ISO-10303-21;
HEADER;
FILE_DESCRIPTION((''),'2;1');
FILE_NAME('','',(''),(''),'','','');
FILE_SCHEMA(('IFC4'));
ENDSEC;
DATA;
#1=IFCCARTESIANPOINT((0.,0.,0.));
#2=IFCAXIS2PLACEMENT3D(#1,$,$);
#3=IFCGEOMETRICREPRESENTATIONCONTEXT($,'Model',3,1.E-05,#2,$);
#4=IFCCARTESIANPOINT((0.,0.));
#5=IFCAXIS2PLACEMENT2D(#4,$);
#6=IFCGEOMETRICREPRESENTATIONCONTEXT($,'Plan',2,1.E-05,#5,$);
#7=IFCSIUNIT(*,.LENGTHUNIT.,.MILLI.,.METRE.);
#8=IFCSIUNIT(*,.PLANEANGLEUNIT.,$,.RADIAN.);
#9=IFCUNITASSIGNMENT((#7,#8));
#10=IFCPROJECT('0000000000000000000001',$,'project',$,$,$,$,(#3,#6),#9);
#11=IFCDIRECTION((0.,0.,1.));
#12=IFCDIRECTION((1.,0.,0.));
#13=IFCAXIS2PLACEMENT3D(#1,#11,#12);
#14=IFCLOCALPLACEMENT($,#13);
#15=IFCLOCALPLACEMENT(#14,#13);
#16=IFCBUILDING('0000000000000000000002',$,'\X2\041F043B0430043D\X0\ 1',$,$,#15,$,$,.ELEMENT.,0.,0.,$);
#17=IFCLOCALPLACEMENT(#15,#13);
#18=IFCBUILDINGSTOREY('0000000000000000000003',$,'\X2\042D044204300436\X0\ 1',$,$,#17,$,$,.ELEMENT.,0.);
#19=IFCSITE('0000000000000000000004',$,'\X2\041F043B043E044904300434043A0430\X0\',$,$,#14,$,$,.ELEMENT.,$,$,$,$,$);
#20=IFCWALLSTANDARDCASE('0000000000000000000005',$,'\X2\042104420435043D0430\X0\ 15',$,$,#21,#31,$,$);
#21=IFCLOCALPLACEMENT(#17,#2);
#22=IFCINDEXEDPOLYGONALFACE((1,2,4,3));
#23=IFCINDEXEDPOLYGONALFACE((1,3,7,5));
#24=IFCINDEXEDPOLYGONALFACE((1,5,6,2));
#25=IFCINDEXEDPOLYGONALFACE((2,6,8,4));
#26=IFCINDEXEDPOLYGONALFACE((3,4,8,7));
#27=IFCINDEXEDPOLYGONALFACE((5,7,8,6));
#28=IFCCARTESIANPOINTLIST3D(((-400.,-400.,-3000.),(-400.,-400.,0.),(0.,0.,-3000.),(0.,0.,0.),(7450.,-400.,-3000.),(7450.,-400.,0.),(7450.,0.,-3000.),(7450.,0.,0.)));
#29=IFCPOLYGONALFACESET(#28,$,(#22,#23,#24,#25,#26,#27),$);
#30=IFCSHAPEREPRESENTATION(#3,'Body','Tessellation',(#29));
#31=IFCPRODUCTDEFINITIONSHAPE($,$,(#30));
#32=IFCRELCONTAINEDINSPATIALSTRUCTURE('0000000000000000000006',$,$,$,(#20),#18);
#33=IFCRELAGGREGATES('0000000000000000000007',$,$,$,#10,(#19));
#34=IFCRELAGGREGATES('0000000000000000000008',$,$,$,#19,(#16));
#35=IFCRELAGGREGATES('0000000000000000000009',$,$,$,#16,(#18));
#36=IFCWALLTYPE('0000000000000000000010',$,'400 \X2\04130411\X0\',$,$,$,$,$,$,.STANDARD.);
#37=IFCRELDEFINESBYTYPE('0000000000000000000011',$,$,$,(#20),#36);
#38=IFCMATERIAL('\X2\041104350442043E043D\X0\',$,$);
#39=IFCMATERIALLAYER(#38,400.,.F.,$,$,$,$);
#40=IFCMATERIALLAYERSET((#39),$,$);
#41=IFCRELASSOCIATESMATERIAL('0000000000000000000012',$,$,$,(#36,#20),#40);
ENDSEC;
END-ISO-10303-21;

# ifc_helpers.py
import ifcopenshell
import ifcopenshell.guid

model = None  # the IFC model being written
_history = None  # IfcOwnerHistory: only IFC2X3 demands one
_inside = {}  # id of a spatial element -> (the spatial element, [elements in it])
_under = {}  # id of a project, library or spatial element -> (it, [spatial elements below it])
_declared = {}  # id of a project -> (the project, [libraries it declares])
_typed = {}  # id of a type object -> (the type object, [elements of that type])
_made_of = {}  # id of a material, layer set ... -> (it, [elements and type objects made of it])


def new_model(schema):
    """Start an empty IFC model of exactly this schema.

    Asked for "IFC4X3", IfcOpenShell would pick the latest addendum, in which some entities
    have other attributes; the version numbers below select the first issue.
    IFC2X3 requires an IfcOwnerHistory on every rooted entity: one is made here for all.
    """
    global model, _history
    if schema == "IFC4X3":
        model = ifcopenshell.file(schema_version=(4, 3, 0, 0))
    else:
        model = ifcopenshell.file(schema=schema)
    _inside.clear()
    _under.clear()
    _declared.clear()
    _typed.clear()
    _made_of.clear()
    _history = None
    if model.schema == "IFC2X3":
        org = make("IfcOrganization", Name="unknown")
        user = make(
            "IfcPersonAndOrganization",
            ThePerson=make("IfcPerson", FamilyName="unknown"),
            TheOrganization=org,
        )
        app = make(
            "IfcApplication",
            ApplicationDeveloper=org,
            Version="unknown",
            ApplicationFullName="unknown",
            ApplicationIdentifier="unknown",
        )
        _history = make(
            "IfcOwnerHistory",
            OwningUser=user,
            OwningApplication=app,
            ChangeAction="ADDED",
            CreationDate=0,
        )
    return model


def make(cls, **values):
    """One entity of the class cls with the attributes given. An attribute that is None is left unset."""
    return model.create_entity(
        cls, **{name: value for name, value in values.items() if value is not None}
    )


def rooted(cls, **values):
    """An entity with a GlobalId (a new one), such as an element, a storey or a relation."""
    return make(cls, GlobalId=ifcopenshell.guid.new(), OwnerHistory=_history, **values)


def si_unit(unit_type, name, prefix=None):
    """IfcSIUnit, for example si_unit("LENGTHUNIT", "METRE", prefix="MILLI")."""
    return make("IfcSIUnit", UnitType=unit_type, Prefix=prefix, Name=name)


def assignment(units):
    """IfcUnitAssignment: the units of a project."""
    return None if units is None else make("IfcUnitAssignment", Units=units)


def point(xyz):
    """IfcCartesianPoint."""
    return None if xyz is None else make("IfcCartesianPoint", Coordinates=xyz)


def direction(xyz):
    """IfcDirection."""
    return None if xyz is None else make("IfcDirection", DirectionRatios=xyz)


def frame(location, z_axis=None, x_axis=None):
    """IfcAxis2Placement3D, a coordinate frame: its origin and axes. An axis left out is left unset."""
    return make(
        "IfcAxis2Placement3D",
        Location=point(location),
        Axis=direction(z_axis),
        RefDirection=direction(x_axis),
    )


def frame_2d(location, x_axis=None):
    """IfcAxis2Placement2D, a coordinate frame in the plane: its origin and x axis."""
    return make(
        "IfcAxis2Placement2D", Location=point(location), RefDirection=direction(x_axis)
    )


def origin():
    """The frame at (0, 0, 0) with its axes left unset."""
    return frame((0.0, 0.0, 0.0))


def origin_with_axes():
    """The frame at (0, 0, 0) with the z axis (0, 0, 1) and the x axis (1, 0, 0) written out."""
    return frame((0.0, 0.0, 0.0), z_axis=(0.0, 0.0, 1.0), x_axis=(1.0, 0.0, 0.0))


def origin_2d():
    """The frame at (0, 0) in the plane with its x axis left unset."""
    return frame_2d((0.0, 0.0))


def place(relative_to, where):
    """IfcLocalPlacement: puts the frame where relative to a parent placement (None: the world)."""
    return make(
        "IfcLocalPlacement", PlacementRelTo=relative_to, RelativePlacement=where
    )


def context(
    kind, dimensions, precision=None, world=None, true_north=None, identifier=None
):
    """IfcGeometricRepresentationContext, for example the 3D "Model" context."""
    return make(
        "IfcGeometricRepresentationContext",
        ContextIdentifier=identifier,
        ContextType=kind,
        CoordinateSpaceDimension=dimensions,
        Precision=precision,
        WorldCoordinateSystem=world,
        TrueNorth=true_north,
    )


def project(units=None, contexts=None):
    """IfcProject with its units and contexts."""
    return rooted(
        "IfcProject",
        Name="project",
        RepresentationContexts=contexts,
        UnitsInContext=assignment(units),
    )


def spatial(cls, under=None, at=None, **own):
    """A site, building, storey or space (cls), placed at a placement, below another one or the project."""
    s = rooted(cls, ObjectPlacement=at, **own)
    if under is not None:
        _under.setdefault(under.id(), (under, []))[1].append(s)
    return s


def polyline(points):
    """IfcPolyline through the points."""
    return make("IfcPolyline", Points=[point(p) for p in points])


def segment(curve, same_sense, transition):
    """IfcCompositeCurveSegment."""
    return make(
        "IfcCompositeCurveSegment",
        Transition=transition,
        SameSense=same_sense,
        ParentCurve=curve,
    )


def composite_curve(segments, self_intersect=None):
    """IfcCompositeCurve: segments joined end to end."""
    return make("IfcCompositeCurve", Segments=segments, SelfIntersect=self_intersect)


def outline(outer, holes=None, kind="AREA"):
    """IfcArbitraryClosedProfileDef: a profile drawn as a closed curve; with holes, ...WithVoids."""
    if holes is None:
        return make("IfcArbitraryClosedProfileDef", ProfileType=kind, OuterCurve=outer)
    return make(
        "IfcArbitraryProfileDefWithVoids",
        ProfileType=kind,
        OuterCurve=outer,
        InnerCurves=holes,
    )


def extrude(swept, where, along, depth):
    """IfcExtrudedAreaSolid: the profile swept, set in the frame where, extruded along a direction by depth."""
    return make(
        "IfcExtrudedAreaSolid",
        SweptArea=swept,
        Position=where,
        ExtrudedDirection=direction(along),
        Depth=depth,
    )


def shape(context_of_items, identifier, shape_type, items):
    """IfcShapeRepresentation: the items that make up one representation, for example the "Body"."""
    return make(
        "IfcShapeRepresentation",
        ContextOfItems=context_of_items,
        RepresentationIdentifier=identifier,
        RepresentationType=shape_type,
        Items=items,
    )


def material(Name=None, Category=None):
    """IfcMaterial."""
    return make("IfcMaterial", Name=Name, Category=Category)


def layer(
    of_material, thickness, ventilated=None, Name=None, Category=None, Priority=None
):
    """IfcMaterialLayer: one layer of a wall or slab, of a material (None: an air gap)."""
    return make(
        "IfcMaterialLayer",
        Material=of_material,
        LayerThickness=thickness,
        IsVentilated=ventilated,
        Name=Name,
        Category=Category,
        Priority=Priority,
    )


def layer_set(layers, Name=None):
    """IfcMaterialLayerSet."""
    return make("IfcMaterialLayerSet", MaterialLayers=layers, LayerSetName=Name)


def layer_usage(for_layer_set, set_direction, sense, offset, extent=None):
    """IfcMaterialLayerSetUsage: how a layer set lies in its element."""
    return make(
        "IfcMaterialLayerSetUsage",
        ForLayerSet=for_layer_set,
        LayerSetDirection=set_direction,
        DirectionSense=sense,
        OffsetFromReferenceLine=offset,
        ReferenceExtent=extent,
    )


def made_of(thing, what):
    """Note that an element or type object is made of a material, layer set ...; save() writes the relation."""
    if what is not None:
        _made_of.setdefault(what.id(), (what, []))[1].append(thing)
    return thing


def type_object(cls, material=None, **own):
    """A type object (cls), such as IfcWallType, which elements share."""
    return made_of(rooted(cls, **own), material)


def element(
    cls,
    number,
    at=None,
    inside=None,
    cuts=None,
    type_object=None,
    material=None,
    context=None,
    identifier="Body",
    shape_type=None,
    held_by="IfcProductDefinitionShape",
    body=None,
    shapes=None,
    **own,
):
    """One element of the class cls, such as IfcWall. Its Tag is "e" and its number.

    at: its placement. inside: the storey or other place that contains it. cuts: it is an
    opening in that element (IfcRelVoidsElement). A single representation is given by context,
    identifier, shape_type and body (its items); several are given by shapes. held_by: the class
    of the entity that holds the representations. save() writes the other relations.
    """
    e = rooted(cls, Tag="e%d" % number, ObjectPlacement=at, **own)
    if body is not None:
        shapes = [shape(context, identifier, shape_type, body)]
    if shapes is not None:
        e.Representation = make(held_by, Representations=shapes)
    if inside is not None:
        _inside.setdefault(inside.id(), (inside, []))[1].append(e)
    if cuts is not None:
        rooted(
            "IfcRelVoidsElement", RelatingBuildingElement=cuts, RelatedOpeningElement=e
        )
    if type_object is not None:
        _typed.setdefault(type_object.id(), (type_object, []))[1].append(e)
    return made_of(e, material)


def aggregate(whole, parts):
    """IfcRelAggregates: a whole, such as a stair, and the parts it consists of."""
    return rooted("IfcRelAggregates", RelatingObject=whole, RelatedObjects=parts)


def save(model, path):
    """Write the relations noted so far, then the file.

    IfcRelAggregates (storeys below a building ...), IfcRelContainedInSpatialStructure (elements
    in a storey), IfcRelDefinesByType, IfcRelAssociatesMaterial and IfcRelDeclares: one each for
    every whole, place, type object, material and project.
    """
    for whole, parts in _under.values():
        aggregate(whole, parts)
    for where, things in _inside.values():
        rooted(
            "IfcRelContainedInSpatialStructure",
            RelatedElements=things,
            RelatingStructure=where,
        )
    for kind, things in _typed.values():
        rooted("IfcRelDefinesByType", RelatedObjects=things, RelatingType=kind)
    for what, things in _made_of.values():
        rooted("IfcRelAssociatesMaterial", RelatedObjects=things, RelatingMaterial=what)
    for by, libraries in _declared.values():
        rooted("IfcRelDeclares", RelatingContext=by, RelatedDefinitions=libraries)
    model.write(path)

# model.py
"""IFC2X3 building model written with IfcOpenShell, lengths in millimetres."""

from ifc_helpers import new_model, si_unit, frame, origin, origin_with_axes, origin_2d, place, context, project, spatial, polyline, segment, composite_curve, outline, extrude, material, layer, layer_set, layer_usage, type_object, element, save


model = new_model("IFC2X3")

# Units and contexts
model_context = context("Model", 3, precision=1e-05, world=origin())
plan_context = context("Plan", 2, precision=1e-05, world=origin_2d())
ifc_project = project(units=[si_unit("LENGTHUNIT", "METRE", prefix="MILLI"), si_unit("PLANEANGLEUNIT", "RADIAN")], contexts=[model_context, plan_context])

# Site, building, storey
site_placement = place(None, origin_with_axes())
site = spatial("IfcSite", under=ifc_project, at=site_placement, Name="Площадка", CompositionType="ELEMENT")
building_placement = place(site_placement, origin_with_axes())
building = spatial("IfcBuilding", under=site, at=building_placement, Name="План 1", CompositionType="ELEMENT", ElevationOfRefHeight=0.0, ElevationOfTerrain=0.0)
storey_placement = place(building_placement, origin_with_axes())
storey = spatial("IfcBuildingStorey", under=building, at=storey_placement, Name="Этаж 1", CompositionType="ELEMENT", Elevation=0.0)

# Wall
ifc_material = material(Name="Бетон")
ifc_layer_1 = layer(ifc_material, 400.0, ventilated=False)
ifc_layer_set_1 = layer_set([ifc_layer_1])
wall_type_1 = type_object("IfcWallType", Name="400 ГБ", PredefinedType="STANDARD", material=ifc_layer_set_1)
ifc_layer_usage_1 = layer_usage(ifc_layer_set_1, "AXIS2", "POSITIVE", 0.0)
wall_1_placement = place(storey_placement, frame((-400.0, -400.0, -3000.0), z_axis=(0.0, 0.0, 1.0), x_axis=(1.0, 0.0, 0.0)))
element("IfcWallStandardCase", 1, at=wall_1_placement, inside=storey, type_object=wall_type_1, material=ifc_layer_usage_1, Name="Стена 15", context=model_context, shape_type="SweptSolid", body=[
    extrude(outline(composite_curve([segment(polyline([(400.0, 400.0), (0.0, 0.0)]), True, "CONTINUOUS"), segment(polyline([(0.0, 0.0), (7850.0, 0.0)]), True, "CONTINUOUS"), segment(polyline([(7850.0, 0.0), (7850.0, 400.0)]), True, "CONTINUOUS"), segment(polyline([(7850.0, 400.0), (400.0, 400.0)]), True, "CONTINUOUS")], self_intersect=False)), origin_with_axes(), (0.0, 0.0, 1.0), 3000.0),
])

save(model, "model.ifc")
